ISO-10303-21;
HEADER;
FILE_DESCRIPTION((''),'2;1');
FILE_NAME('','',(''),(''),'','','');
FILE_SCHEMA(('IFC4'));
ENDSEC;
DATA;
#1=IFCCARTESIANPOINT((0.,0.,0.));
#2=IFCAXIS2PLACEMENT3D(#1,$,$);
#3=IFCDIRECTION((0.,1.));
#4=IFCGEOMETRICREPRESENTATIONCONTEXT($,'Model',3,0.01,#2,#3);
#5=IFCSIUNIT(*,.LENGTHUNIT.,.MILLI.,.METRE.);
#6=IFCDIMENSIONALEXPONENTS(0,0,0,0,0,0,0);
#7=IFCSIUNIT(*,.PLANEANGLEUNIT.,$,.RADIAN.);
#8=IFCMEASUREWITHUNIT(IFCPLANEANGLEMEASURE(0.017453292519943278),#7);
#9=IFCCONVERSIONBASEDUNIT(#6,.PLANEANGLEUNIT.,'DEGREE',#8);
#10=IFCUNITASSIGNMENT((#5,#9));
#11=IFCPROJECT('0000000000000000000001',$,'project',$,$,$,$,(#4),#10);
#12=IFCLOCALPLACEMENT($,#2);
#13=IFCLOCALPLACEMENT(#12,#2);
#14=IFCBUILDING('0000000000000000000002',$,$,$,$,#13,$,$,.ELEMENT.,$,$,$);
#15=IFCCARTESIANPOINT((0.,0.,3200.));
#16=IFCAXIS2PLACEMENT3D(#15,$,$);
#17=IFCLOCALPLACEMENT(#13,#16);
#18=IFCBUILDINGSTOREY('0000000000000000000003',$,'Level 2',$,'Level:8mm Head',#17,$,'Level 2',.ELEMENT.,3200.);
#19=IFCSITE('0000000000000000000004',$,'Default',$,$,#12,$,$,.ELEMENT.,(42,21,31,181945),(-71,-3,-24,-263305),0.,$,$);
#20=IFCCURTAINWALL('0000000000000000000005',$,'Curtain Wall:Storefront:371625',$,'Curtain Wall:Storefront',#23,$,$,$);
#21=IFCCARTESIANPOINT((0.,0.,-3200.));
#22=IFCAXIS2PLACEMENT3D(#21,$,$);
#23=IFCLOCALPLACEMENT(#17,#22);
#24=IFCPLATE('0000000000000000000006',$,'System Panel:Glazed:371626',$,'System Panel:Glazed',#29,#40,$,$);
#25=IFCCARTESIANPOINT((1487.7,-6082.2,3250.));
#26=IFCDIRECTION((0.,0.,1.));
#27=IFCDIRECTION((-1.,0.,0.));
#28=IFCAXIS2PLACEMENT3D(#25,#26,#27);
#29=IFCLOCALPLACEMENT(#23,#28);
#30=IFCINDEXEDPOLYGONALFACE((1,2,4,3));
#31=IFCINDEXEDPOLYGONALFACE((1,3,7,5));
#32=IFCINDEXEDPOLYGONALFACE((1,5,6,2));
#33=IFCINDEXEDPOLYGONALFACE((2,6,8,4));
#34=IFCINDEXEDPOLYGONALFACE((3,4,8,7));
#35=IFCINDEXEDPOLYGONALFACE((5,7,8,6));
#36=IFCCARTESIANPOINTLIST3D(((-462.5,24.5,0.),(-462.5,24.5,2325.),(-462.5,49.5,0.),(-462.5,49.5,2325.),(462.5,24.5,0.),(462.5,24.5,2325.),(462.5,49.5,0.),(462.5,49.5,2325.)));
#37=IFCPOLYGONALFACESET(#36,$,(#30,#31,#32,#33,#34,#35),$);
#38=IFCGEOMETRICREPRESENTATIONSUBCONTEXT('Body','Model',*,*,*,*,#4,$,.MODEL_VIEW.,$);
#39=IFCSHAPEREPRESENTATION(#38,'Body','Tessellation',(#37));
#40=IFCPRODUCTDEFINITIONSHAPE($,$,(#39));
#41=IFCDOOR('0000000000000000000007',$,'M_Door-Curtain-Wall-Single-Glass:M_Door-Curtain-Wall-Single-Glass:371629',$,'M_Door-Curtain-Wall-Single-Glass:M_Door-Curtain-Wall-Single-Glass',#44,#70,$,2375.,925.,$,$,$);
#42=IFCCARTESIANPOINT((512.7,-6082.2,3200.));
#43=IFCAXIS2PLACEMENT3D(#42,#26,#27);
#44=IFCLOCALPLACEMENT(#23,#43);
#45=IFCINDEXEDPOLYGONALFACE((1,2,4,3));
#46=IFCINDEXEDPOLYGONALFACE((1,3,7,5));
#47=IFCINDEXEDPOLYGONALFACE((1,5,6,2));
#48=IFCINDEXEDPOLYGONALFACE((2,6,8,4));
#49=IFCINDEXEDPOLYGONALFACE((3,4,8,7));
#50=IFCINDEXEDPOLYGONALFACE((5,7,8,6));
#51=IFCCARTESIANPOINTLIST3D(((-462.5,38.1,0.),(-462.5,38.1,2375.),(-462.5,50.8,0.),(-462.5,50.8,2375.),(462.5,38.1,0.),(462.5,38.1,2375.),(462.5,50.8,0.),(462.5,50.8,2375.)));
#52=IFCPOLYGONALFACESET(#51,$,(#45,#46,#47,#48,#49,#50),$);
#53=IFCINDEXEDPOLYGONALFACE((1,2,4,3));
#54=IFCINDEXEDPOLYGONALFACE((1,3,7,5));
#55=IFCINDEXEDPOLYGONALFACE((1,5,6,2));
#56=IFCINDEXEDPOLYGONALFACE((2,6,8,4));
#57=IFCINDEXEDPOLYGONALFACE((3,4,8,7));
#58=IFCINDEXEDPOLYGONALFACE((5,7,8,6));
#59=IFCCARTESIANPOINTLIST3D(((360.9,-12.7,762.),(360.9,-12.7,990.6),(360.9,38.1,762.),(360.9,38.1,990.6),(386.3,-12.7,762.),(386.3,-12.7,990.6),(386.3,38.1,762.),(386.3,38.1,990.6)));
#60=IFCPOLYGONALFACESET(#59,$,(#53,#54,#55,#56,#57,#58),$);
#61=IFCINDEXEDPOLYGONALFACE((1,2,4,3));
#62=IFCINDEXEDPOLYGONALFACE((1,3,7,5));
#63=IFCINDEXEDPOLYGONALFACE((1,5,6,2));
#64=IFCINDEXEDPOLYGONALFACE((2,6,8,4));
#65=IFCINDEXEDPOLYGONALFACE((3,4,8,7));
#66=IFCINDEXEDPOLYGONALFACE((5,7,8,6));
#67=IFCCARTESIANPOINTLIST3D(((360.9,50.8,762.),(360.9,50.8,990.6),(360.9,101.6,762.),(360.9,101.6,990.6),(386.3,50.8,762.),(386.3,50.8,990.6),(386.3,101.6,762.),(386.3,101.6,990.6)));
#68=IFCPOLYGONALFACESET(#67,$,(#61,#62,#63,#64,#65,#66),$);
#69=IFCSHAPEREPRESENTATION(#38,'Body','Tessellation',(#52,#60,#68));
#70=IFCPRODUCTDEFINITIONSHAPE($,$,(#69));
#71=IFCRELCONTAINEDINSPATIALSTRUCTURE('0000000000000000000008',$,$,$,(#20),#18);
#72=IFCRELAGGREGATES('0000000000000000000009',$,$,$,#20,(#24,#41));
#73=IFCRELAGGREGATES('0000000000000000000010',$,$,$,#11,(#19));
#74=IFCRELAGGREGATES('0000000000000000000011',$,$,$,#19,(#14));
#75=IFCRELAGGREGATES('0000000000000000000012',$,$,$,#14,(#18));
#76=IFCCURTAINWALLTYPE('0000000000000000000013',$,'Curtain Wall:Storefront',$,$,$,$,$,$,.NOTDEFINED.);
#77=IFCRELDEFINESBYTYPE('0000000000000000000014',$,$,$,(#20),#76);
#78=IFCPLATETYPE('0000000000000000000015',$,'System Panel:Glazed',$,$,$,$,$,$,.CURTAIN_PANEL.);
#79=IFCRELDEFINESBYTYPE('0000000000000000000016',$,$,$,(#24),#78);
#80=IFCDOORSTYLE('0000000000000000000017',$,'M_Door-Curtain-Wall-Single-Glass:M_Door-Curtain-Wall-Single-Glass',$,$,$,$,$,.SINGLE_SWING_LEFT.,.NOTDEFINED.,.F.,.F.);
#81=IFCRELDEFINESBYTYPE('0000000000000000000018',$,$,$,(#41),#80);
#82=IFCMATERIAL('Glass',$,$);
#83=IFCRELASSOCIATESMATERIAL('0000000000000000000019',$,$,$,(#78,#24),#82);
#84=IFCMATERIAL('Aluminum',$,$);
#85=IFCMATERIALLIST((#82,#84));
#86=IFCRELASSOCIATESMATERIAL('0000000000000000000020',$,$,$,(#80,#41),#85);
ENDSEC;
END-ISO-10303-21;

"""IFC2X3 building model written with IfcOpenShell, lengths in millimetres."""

from ifc_helpers import new_model, entity, si_unit, converted_unit, direction, frame, frame_2d, origin, origin_2d_with_axis, place, context, subcontext, project, spatial, rectangle, extrude, source, transform, mapped, material, material_list, type_object, type_shapes, element, aggregate, save


model = new_model("IFC2X3")

# Units and contexts
model_context = context("Model", 3, precision=0.01, world=origin(), true_north=direction((0.0, 1.0)))
body_context = subcontext(model_context, "Body", "Model", "MODEL_VIEW")
ifc_project = project(units=[si_unit("LENGTHUNIT", "METRE", prefix="MILLI"), converted_unit("PLANEANGLEUNIT", "DEGREE", entity("IfcPlaneAngleMeasure", 0.017453292519943278), si_unit("PLANEANGLEUNIT", "RADIAN"), dimensions=[0, 0, 0, 0, 0, 0, 0])], contexts=[model_context])

# Site, building, storey
site_placement = place(None, origin())
site = spatial("IfcSite", under=ifc_project, at=site_placement, Name="Default", CompositionType="ELEMENT", RefLatitude=(42, 21, 31, 181945), RefLongitude=(-71, -3, -24, -263305), RefElevation=0.0)
building_placement = place(site_placement, origin())
building = spatial("IfcBuilding", under=site, at=building_placement, CompositionType="ELEMENT")
storey_placement = place(building_placement, frame((0.0, 0.0, 3200.0)))
storey = spatial("IfcBuildingStorey", under=building, at=storey_placement, Name="Level 2", ObjectType="Level:8mm Head", LongName="Level 2", CompositionType="ELEMENT", Elevation=3200.0)

# Curtain wall
curtain_wall_type = type_object("IfcCurtainWallType", Name="Curtain Wall:Storefront", PredefinedType="NOTDEFINED")
curtain_wall_1_placement = place(storey_placement, frame((0.0, 0.0, -3200.0)))
curtain_wall_1 = element("IfcCurtainWall", 1, at=curtain_wall_1_placement, inside=storey, type_object=curtain_wall_type, Name="Curtain Wall:Storefront:371625", ObjectType="Curtain Wall:Storefront")

# Plate
ifc_material_1 = material(Name="Glass")
plate_type_1 = type_object("IfcPlateType", Name="System Panel:Glazed", PredefinedType="CURTAIN_PANEL", material=ifc_material_1)
shared_shape_1 = source(origin(), body_context, "Body", "SweptSolid", [
    extrude(rectangle(XDim=25.0, YDim=925.0, at=origin_2d_with_axis()), frame((0.0, 37.0, 0.0), z_axis=(0.0, 0.0, 1.0), x_axis=(0.0, 1.0, 0.0)), (0.0, 0.0, 1.0), 2325.0),
])
type_shapes(plate_type_1, [shared_shape_1])
plate_1_placement = place(curtain_wall_1_placement, frame((1487.7, -6082.2, 3250.0), z_axis=(0.0, 0.0, 1.0), x_axis=(-1.0, 0.0, 0.0)))
plate_1 = element("IfcPlate", 2, at=plate_1_placement, type_object=plate_type_1, material=ifc_material_1, Name="System Panel:Glazed:371626", ObjectType="System Panel:Glazed", context=body_context, shape_type="MappedRepresentation", body=[
    mapped(shared_shape_1, transform((0.0, 0.0, 0.0), scale=1.0)),
])

# Door
ifc_material_2 = material(Name="Aluminum")
ifc_material_list = material_list([ifc_material_1, ifc_material_2])
door_style = type_object("IfcDoorStyle", Name="M_Door-Curtain-Wall-Single-Glass:M_Door-Curtain-Wall-Single-Glass", ConstructionType="NOTDEFINED", OperationType="SINGLE_SWING_LEFT", ParameterTakesPrecedence=False, Sizeable=False, material=ifc_material_list)
shared_shape_2 = source(origin(), body_context, "Body", "SweptSolid", [
    extrude(rectangle(XDim=12.7, YDim=925.0, at=frame_2d((0.0, 0.0), x_axis=(1.0, 0.0))), frame((0.0, 44.5, 0.0), z_axis=(0.0, 0.0, 1.0), x_axis=(0.0, -1.0, 0.0)), (0.0, 0.0, 1.0), 2375.0),
    extrude(rectangle(XDim=25.4, YDim=50.8, at=frame_2d((0.0, 0.0), x_axis=(1.0, 0.0))), frame((373.6, 12.7, 762.0)), (0.0, 0.0, 1.0), 228.6),
    extrude(rectangle(XDim=25.4, YDim=50.8, at=frame_2d((0.0, 0.0), x_axis=(1.0, 0.0))), frame((373.6, 76.2, 762.0), z_axis=(0.0, 0.0, 1.0), x_axis=(-1.0, 0.0, 0.0)), (0.0, 0.0, 1.0), 228.6),
])
type_shapes(door_style, [shared_shape_2])
door_placement = place(curtain_wall_1_placement, frame((512.7, -6082.2, 3200.0), z_axis=(0.0, 0.0, 1.0), x_axis=(-1.0, 0.0, 0.0)))
door = element("IfcDoor", 3, at=door_placement, type_object=door_style, material=ifc_material_list, Name="M_Door-Curtain-Wall-Single-Glass:M_Door-Curtain-Wall-Single-Glass:371629", ObjectType="M_Door-Curtain-Wall-Single-Glass:M_Door-Curtain-Wall-Single-Glass", OverallHeight=2375.0, OverallWidth=925.0, context=body_context, shape_type="MappedRepresentation", body=[
    mapped(shared_shape_2, transform((0.0, 0.0, 0.0), scale=1.0)),
])
aggregate(curtain_wall_1, [plate_1, door])

save(model, "model.ifc")
